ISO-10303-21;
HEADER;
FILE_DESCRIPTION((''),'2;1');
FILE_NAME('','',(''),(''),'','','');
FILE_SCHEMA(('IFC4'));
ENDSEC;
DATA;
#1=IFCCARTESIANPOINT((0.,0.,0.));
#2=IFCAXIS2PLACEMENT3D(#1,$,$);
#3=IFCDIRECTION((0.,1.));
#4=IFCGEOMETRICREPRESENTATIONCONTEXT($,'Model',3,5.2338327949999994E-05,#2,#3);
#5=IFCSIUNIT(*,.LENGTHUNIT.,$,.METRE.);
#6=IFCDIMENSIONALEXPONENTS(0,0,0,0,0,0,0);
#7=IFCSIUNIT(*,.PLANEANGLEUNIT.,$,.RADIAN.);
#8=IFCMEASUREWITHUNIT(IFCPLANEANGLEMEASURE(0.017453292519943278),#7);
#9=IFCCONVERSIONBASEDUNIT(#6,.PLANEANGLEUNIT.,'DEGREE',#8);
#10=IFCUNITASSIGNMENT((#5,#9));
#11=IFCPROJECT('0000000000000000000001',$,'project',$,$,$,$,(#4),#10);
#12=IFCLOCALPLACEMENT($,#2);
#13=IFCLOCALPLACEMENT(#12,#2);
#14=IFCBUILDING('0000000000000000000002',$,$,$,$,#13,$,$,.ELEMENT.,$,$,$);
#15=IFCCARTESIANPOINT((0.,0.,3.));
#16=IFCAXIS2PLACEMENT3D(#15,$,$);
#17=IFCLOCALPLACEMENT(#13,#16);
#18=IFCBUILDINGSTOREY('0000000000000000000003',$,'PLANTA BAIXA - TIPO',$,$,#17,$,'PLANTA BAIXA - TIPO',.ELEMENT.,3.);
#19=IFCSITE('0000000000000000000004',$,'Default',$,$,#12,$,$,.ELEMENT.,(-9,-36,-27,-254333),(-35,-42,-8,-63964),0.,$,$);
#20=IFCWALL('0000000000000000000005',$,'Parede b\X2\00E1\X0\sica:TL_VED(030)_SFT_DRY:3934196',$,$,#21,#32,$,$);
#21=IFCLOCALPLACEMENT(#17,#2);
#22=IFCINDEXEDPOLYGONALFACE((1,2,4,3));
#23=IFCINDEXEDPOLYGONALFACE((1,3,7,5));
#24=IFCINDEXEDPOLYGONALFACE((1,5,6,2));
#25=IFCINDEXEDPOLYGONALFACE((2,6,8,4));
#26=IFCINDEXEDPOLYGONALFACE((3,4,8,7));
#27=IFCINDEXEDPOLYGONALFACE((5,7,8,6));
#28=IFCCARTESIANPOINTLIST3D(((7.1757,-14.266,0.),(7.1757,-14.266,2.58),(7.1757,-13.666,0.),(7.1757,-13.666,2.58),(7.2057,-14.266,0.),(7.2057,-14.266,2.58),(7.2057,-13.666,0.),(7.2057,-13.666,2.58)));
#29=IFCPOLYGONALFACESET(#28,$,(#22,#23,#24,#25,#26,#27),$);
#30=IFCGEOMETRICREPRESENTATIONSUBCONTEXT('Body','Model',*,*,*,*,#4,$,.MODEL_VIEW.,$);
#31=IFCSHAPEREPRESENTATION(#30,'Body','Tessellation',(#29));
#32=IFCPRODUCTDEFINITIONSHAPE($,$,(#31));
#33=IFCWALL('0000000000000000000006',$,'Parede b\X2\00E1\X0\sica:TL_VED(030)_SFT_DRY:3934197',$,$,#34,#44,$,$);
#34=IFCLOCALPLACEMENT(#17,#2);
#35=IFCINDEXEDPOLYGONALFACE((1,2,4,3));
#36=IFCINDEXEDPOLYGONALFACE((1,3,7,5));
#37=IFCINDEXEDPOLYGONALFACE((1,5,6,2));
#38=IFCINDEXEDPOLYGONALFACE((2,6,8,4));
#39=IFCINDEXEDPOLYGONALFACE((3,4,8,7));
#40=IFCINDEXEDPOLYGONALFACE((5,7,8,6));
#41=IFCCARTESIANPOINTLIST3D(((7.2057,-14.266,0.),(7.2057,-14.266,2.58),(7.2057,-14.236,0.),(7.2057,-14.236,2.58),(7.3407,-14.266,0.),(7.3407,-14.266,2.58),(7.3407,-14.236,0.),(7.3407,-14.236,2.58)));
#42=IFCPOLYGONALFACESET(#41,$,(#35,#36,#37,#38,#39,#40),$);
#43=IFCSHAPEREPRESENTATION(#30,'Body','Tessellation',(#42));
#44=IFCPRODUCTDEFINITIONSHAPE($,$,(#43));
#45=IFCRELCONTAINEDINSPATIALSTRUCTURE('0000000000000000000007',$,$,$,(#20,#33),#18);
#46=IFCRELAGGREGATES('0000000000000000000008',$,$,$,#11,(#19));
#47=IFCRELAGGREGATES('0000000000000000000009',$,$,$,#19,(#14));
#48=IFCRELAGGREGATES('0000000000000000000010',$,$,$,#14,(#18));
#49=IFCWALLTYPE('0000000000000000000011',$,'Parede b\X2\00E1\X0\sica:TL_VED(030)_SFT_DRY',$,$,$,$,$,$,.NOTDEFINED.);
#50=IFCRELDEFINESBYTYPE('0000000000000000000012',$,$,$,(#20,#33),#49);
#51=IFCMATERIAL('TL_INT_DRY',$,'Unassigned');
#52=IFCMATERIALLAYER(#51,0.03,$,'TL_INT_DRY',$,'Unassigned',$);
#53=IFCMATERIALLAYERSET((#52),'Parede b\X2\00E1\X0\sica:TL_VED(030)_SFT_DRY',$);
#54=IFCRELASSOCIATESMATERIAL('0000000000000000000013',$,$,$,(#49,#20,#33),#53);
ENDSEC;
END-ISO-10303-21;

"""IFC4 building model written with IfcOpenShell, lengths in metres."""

from ifc_helpers import new_model, entity, si_unit, converted_unit, direction, frame, frame_2d, origin, place, context, subcontext, project, spatial, rectangle, extrude, material, layer, layer_set, layer_usage, type_object, element, save


model = new_model("IFC4")

# Units and contexts
model_context = context("Model", 3, precision=5.2338327949999994e-05, world=origin(), true_north=direction((0.0, 1.0)))
body_context = subcontext(model_context, "Body", "Model", "MODEL_VIEW")
ifc_project = project(units=[si_unit("LENGTHUNIT", "METRE"), converted_unit("PLANEANGLEUNIT", "DEGREE", entity("IfcPlaneAngleMeasure", 0.017453292519943278), si_unit("PLANEANGLEUNIT", "RADIAN"), dimensions=[0, 0, 0, 0, 0, 0, 0])], contexts=[model_context])

# Site, building, storey
site_placement = place(None, frame((0.0, 0.0, 0.0)))
site = spatial("IfcSite", under=ifc_project, at=site_placement, Name="Default", CompositionType="ELEMENT", RefLatitude=(-9, -36, -27, -254333), RefLongitude=(-35, -42, -8, -63964), RefElevation=0.0)
building_placement = place(site_placement, origin())
building = spatial("IfcBuilding", under=site, at=building_placement, CompositionType="ELEMENT")
storey_placement = place(building_placement, frame((0.0, 0.0, 3.0)))
storey = spatial("IfcBuildingStorey", under=building, at=storey_placement, Name="PLANTA BAIXA - TIPO", LongName="PLANTA BAIXA - TIPO", CompositionType="ELEMENT", Elevation=3.0)

# Walls
ifc_material_1 = material(Name="TL_INT_DRY", Category="Unassigned")
ifc_layer_1 = layer(ifc_material_1, 0.03, Name="TL_INT_DRY", Category="Unassigned")
ifc_layer_set_1 = layer_set([ifc_layer_1], Name="Parede básica:TL_VED(030)_SFT_DRY")
ifc_layer_usage_1 = layer_usage(ifc_layer_set_1, "AXIS2", "POSITIVE", -0.015)
wall_type_1 = type_object("IfcWallType", Name="Parede básica:TL_VED(030)_SFT_DRY", PredefinedType="NOTDEFINED", material=ifc_layer_set_1)
wall_1_placement = place(storey_placement, frame((7.1907, -13.666, 0.0), z_axis=(0.0, 0.0, 1.0), x_axis=(0.0, -1.0, 0.0)))
element("IfcWall", 1, at=wall_1_placement, inside=storey, type_object=wall_type_1, material=ifc_layer_usage_1, Name="Parede básica:TL_VED(030)_SFT_DRY:3934196", context=body_context, shape_type="SweptSolid", body=[
    extrude(rectangle(XDim=0.6, YDim=0.03, at=frame_2d((0.3, 0.0), x_axis=(-1.0, 0.0))), origin(), (0.0, 0.0, 1.0), 2.58),
])
ifc_layer_usage_2 = layer_usage(ifc_layer_set_1, "AXIS2", "POSITIVE", -0.015)
wall_2_placement = place(storey_placement, frame((7.2057, -14.251, 0.0)))
element("IfcWall", 2, at=wall_2_placement, inside=storey, type_object=wall_type_1, material=ifc_layer_usage_2, Name="Parede básica:TL_VED(030)_SFT_DRY:3934197", context=body_context, shape_type="SweptSolid", body=[
    extrude(rectangle(XDim=0.135, YDim=0.03, at=frame_2d((0.0675, 0.0), x_axis=(-1.0, 0.0))), origin(), (0.0, 0.0, 1.0), 2.58),
])

save(model, "model.ifc")
